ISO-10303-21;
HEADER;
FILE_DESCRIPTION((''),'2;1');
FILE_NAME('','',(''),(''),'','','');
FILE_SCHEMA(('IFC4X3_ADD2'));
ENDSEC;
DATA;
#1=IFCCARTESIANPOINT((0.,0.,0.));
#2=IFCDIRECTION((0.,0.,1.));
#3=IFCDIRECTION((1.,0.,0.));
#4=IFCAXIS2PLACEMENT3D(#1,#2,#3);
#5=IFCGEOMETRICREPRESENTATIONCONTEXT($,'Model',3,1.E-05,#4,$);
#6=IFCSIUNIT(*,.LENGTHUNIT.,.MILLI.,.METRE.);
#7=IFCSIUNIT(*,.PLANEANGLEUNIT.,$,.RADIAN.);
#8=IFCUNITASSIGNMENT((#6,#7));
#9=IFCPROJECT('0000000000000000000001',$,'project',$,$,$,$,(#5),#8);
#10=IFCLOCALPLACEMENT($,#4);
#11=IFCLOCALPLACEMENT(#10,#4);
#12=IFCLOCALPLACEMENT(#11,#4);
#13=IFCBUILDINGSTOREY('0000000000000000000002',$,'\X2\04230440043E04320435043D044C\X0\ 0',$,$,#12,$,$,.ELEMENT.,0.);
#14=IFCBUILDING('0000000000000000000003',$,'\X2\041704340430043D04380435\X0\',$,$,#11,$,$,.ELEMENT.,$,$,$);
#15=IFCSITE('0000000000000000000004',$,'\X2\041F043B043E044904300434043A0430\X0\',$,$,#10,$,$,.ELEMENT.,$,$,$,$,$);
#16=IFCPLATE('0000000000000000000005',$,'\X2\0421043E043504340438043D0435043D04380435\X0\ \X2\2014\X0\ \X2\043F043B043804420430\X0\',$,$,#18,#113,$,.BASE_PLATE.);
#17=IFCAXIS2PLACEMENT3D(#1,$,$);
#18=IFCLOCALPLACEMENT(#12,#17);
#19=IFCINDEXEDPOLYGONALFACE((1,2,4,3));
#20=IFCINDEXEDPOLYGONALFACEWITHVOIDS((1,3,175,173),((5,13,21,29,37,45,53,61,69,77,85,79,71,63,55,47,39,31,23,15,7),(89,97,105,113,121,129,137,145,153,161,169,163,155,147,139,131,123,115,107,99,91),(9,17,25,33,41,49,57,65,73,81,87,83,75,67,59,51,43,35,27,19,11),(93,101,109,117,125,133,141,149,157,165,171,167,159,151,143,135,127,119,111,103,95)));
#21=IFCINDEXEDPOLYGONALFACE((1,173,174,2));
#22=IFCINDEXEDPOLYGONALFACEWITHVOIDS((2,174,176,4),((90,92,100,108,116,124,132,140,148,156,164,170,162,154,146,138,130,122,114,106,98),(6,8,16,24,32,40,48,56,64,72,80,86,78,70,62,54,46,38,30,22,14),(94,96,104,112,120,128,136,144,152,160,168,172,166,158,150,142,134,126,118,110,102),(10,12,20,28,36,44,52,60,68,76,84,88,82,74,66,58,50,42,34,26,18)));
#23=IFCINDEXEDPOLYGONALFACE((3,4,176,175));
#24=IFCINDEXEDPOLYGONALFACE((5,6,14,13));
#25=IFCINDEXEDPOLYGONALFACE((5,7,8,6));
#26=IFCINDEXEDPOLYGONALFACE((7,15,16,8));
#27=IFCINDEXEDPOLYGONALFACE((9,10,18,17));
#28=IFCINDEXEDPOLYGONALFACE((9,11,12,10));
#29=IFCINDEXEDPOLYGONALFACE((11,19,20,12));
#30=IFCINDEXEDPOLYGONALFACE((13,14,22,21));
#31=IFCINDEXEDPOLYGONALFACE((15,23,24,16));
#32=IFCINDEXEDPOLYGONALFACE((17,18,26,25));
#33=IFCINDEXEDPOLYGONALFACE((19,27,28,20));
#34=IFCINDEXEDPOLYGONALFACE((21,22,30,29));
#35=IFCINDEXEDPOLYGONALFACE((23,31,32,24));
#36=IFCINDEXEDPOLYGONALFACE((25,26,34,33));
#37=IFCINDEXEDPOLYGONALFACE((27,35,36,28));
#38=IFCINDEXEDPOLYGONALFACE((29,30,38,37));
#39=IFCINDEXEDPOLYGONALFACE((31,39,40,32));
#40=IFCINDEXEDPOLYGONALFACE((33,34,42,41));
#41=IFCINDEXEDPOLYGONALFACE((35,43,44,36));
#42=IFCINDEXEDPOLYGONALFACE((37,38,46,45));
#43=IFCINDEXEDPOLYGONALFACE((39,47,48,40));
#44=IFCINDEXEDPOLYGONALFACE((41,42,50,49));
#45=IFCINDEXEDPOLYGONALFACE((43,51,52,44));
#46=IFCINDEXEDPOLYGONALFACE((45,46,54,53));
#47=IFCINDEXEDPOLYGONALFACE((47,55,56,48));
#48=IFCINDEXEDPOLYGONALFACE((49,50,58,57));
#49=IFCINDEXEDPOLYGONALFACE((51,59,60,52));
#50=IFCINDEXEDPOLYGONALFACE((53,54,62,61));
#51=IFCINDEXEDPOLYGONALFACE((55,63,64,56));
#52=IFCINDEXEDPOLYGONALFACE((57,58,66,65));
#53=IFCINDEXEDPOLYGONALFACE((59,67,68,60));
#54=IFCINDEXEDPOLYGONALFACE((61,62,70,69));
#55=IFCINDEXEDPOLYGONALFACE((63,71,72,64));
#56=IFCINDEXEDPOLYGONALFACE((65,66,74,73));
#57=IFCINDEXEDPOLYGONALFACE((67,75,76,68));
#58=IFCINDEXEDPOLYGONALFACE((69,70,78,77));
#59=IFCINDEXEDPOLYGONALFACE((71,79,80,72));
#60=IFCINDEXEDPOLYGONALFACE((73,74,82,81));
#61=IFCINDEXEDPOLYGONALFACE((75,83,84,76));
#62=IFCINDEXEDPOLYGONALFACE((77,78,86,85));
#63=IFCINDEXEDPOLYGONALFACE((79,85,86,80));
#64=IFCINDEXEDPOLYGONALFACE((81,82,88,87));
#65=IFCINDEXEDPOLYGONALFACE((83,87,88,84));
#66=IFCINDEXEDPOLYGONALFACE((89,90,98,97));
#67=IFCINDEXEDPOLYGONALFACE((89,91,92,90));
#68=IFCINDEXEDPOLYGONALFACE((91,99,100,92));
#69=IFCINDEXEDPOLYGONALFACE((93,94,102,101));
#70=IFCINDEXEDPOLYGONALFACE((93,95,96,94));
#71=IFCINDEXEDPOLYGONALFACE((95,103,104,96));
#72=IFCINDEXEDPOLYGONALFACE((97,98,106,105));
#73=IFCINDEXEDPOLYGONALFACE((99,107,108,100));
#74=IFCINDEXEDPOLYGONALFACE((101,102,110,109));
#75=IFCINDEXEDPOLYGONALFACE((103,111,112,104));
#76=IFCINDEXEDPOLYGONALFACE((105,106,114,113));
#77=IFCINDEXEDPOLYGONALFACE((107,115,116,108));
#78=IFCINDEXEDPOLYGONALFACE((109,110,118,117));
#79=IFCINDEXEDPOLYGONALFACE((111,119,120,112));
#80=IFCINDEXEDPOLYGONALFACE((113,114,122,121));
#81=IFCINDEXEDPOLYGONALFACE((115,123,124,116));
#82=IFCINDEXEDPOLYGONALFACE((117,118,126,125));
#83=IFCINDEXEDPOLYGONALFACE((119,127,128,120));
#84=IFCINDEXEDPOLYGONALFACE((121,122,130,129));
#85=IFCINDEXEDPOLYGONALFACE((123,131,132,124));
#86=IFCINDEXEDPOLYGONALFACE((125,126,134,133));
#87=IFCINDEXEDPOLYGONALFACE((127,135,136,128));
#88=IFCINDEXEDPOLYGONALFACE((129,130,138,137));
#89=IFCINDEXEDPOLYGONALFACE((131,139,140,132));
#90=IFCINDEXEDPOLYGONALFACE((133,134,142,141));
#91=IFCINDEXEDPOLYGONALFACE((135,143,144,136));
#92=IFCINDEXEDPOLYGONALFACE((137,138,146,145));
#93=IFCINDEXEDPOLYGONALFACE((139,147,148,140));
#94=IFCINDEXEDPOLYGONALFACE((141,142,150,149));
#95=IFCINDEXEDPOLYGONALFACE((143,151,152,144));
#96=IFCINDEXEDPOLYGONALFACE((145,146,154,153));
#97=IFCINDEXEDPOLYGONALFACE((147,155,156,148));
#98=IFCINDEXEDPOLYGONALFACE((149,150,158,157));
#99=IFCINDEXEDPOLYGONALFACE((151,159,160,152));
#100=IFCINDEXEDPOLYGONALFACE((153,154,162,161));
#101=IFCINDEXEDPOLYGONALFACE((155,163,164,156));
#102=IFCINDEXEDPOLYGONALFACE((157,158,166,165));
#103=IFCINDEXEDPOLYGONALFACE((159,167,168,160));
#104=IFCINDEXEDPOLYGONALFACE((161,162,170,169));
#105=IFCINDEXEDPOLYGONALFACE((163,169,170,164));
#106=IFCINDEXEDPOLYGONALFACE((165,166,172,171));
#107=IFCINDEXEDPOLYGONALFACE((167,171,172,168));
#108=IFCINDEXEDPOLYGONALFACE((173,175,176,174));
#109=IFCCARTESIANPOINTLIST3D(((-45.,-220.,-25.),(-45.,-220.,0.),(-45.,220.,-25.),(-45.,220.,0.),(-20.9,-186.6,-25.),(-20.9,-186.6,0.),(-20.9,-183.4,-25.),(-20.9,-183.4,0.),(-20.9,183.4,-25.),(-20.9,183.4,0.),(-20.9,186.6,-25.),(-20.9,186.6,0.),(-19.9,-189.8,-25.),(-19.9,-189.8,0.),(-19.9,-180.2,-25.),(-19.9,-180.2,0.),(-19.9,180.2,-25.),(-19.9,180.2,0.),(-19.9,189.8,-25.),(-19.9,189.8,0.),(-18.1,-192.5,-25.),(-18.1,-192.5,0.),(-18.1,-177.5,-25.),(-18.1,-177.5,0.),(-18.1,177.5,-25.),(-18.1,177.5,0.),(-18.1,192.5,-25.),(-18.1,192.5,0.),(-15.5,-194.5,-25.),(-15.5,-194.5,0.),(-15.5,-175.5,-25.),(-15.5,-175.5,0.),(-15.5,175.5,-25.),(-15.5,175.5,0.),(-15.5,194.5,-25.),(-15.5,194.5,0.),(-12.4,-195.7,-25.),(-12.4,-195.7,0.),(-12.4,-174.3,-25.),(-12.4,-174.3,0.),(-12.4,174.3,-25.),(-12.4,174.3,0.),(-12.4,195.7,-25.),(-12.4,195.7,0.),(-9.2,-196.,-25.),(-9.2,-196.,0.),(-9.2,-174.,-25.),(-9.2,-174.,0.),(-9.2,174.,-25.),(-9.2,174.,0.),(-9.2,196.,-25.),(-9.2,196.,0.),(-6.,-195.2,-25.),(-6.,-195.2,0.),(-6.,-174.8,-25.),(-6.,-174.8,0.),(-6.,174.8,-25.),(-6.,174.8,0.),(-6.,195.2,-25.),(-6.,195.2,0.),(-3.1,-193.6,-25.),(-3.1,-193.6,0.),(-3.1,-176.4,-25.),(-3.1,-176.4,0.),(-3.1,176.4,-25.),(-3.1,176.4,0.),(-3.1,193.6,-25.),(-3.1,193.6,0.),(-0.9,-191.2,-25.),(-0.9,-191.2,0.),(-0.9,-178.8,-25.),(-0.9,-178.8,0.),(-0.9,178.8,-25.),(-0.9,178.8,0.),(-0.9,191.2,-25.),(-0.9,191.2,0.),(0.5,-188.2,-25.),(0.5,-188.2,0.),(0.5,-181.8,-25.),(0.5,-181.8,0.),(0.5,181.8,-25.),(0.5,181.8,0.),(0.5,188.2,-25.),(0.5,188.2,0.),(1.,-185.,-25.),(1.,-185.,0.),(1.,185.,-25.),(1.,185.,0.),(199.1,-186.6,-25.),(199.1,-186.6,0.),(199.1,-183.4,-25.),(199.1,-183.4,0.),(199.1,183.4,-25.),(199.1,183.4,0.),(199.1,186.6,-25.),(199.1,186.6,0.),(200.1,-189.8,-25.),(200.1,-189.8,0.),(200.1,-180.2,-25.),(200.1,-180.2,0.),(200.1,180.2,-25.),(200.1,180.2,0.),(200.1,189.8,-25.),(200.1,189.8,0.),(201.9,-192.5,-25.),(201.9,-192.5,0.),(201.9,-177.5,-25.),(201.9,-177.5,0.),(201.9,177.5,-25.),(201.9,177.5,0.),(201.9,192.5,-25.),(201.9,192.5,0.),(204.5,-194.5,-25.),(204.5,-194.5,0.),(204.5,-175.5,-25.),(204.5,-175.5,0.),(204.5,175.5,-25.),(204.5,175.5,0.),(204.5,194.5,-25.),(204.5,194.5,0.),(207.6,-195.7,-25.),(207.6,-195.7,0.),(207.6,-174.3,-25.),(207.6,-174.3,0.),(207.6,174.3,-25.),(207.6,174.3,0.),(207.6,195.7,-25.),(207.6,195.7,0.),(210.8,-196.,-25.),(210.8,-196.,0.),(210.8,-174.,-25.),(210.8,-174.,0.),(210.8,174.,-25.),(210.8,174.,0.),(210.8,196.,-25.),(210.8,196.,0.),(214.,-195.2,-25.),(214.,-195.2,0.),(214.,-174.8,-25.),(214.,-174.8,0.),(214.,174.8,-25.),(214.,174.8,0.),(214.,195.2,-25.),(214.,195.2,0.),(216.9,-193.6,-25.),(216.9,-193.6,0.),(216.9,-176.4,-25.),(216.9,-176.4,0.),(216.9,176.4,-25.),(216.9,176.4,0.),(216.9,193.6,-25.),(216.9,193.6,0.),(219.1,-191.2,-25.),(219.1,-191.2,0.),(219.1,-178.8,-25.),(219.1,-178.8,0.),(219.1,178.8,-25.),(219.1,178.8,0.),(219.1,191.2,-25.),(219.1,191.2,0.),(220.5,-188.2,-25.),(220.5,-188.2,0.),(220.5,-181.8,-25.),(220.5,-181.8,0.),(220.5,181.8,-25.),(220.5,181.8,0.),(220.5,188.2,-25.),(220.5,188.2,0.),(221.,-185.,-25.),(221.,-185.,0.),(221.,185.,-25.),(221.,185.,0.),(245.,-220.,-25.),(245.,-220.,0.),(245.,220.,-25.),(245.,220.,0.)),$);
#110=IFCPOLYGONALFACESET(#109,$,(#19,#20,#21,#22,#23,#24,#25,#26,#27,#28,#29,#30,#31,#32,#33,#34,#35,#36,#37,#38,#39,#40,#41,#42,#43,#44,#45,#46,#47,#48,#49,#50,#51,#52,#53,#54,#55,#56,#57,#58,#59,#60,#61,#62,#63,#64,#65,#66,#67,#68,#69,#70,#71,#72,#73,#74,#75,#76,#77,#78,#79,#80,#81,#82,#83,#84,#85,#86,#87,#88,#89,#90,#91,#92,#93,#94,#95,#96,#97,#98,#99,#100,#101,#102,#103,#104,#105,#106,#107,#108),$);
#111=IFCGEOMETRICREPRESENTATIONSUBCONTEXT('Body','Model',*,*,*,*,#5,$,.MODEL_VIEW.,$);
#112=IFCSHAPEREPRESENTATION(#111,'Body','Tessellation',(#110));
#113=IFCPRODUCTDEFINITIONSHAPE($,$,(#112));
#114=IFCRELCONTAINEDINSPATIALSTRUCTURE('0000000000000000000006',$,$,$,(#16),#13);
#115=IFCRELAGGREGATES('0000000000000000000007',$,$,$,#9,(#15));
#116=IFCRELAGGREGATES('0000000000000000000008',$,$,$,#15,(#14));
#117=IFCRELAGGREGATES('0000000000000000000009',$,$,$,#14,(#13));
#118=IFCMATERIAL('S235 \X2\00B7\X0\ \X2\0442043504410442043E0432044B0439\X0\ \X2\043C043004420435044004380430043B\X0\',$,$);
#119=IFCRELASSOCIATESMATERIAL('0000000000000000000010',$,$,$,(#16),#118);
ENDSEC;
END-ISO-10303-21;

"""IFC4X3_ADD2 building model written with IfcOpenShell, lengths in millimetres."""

from ifc_helpers import new_model, si_unit, frame, origin_with_axes, place, context, subcontext, project, spatial, polyline, circle, outline, extrude, material, element, save


model = new_model("IFC4X3_ADD2")

# Units and contexts
model_context = context("Model", 3, precision=1e-05, world=origin_with_axes())
body_context = subcontext(model_context, "Body", "Model", "MODEL_VIEW")
ifc_project = project(units=[si_unit("LENGTHUNIT", "METRE", prefix="MILLI"), si_unit("PLANEANGLEUNIT", "RADIAN")], contexts=[model_context])

# Site, building, storey
site_placement = place(None, origin_with_axes())
site = spatial("IfcSite", under=ifc_project, at=site_placement, Name="Площадка", CompositionType="ELEMENT")
building_placement = place(site_placement, origin_with_axes())
building = spatial("IfcBuilding", under=site, at=building_placement, Name="Здание", CompositionType="ELEMENT")
storey_placement = place(building_placement, origin_with_axes())
storey = spatial("IfcBuildingStorey", under=building, at=storey_placement, Name="Уровень 0", CompositionType="ELEMENT", Elevation=0.0)

# Shared definitions
ifc_material = material(Name="S235 · тестовый материал")

# Plate, openings
plate_1_placement = place(storey_placement, frame((-45.0, -220.0, -25.0), z_axis=(0.0, 0.0, 1.0), x_axis=(1.0, 0.0, 0.0)))
plate_1 = element("IfcPlate", 1, at=plate_1_placement, inside=storey, material=ifc_material, Name="Соединение — плита", PredefinedType="BASE_PLATE", context=body_context, shape_type="SweptSolid", body=[
    extrude(outline(polyline([(0.0, 0.0), (290.0, 0.0), (290.0, 440.0), (0.0, 440.0), (0.0, 0.0)])), origin_with_axes(), (0.0, 0.0, 1.0), 25.0),
])
opening_1_placement = place(plate_1_placement, frame((35.0, 35.0, -1.0), z_axis=(0.0, 0.0, 1.0), x_axis=(1.0, 0.0, 0.0)))
element("IfcOpeningElement", 2, at=opening_1_placement, cuts=plate_1, PredefinedType="OPENING", context=body_context, shape_type="SweptSolid", body=[
    extrude(circle(Radius=11.0), origin_with_axes(), (0.0, 0.0, 1.0), 27.0),
])
opening_2_placement = place(plate_1_placement, frame((255.0, 35.0, -1.0), z_axis=(0.0, 0.0, 1.0), x_axis=(1.0, 0.0, 0.0)))
element("IfcOpeningElement", 3, at=opening_2_placement, cuts=plate_1, PredefinedType="OPENING", context=body_context, shape_type="SweptSolid", body=[
    extrude(circle(Radius=11.0), origin_with_axes(), (0.0, 0.0, 1.0), 27.0),
])
opening_3_placement = place(plate_1_placement, frame((35.0, 405.0, -1.0), z_axis=(0.0, 0.0, 1.0), x_axis=(1.0, 0.0, 0.0)))
element("IfcOpeningElement", 4, at=opening_3_placement, cuts=plate_1, PredefinedType="OPENING", context=body_context, shape_type="SweptSolid", body=[
    extrude(circle(Radius=11.0), origin_with_axes(), (0.0, 0.0, 1.0), 27.0),
])
opening_4_placement = place(plate_1_placement, frame((255.0, 405.0, -1.0), z_axis=(0.0, 0.0, 1.0), x_axis=(1.0, 0.0, 0.0)))
element("IfcOpeningElement", 5, at=opening_4_placement, cuts=plate_1, PredefinedType="OPENING", context=body_context, shape_type="SweptSolid", body=[
    extrude(circle(Radius=11.0), origin_with_axes(), (0.0, 0.0, 1.0), 27.0),
])

save(model, "model.ifc")
